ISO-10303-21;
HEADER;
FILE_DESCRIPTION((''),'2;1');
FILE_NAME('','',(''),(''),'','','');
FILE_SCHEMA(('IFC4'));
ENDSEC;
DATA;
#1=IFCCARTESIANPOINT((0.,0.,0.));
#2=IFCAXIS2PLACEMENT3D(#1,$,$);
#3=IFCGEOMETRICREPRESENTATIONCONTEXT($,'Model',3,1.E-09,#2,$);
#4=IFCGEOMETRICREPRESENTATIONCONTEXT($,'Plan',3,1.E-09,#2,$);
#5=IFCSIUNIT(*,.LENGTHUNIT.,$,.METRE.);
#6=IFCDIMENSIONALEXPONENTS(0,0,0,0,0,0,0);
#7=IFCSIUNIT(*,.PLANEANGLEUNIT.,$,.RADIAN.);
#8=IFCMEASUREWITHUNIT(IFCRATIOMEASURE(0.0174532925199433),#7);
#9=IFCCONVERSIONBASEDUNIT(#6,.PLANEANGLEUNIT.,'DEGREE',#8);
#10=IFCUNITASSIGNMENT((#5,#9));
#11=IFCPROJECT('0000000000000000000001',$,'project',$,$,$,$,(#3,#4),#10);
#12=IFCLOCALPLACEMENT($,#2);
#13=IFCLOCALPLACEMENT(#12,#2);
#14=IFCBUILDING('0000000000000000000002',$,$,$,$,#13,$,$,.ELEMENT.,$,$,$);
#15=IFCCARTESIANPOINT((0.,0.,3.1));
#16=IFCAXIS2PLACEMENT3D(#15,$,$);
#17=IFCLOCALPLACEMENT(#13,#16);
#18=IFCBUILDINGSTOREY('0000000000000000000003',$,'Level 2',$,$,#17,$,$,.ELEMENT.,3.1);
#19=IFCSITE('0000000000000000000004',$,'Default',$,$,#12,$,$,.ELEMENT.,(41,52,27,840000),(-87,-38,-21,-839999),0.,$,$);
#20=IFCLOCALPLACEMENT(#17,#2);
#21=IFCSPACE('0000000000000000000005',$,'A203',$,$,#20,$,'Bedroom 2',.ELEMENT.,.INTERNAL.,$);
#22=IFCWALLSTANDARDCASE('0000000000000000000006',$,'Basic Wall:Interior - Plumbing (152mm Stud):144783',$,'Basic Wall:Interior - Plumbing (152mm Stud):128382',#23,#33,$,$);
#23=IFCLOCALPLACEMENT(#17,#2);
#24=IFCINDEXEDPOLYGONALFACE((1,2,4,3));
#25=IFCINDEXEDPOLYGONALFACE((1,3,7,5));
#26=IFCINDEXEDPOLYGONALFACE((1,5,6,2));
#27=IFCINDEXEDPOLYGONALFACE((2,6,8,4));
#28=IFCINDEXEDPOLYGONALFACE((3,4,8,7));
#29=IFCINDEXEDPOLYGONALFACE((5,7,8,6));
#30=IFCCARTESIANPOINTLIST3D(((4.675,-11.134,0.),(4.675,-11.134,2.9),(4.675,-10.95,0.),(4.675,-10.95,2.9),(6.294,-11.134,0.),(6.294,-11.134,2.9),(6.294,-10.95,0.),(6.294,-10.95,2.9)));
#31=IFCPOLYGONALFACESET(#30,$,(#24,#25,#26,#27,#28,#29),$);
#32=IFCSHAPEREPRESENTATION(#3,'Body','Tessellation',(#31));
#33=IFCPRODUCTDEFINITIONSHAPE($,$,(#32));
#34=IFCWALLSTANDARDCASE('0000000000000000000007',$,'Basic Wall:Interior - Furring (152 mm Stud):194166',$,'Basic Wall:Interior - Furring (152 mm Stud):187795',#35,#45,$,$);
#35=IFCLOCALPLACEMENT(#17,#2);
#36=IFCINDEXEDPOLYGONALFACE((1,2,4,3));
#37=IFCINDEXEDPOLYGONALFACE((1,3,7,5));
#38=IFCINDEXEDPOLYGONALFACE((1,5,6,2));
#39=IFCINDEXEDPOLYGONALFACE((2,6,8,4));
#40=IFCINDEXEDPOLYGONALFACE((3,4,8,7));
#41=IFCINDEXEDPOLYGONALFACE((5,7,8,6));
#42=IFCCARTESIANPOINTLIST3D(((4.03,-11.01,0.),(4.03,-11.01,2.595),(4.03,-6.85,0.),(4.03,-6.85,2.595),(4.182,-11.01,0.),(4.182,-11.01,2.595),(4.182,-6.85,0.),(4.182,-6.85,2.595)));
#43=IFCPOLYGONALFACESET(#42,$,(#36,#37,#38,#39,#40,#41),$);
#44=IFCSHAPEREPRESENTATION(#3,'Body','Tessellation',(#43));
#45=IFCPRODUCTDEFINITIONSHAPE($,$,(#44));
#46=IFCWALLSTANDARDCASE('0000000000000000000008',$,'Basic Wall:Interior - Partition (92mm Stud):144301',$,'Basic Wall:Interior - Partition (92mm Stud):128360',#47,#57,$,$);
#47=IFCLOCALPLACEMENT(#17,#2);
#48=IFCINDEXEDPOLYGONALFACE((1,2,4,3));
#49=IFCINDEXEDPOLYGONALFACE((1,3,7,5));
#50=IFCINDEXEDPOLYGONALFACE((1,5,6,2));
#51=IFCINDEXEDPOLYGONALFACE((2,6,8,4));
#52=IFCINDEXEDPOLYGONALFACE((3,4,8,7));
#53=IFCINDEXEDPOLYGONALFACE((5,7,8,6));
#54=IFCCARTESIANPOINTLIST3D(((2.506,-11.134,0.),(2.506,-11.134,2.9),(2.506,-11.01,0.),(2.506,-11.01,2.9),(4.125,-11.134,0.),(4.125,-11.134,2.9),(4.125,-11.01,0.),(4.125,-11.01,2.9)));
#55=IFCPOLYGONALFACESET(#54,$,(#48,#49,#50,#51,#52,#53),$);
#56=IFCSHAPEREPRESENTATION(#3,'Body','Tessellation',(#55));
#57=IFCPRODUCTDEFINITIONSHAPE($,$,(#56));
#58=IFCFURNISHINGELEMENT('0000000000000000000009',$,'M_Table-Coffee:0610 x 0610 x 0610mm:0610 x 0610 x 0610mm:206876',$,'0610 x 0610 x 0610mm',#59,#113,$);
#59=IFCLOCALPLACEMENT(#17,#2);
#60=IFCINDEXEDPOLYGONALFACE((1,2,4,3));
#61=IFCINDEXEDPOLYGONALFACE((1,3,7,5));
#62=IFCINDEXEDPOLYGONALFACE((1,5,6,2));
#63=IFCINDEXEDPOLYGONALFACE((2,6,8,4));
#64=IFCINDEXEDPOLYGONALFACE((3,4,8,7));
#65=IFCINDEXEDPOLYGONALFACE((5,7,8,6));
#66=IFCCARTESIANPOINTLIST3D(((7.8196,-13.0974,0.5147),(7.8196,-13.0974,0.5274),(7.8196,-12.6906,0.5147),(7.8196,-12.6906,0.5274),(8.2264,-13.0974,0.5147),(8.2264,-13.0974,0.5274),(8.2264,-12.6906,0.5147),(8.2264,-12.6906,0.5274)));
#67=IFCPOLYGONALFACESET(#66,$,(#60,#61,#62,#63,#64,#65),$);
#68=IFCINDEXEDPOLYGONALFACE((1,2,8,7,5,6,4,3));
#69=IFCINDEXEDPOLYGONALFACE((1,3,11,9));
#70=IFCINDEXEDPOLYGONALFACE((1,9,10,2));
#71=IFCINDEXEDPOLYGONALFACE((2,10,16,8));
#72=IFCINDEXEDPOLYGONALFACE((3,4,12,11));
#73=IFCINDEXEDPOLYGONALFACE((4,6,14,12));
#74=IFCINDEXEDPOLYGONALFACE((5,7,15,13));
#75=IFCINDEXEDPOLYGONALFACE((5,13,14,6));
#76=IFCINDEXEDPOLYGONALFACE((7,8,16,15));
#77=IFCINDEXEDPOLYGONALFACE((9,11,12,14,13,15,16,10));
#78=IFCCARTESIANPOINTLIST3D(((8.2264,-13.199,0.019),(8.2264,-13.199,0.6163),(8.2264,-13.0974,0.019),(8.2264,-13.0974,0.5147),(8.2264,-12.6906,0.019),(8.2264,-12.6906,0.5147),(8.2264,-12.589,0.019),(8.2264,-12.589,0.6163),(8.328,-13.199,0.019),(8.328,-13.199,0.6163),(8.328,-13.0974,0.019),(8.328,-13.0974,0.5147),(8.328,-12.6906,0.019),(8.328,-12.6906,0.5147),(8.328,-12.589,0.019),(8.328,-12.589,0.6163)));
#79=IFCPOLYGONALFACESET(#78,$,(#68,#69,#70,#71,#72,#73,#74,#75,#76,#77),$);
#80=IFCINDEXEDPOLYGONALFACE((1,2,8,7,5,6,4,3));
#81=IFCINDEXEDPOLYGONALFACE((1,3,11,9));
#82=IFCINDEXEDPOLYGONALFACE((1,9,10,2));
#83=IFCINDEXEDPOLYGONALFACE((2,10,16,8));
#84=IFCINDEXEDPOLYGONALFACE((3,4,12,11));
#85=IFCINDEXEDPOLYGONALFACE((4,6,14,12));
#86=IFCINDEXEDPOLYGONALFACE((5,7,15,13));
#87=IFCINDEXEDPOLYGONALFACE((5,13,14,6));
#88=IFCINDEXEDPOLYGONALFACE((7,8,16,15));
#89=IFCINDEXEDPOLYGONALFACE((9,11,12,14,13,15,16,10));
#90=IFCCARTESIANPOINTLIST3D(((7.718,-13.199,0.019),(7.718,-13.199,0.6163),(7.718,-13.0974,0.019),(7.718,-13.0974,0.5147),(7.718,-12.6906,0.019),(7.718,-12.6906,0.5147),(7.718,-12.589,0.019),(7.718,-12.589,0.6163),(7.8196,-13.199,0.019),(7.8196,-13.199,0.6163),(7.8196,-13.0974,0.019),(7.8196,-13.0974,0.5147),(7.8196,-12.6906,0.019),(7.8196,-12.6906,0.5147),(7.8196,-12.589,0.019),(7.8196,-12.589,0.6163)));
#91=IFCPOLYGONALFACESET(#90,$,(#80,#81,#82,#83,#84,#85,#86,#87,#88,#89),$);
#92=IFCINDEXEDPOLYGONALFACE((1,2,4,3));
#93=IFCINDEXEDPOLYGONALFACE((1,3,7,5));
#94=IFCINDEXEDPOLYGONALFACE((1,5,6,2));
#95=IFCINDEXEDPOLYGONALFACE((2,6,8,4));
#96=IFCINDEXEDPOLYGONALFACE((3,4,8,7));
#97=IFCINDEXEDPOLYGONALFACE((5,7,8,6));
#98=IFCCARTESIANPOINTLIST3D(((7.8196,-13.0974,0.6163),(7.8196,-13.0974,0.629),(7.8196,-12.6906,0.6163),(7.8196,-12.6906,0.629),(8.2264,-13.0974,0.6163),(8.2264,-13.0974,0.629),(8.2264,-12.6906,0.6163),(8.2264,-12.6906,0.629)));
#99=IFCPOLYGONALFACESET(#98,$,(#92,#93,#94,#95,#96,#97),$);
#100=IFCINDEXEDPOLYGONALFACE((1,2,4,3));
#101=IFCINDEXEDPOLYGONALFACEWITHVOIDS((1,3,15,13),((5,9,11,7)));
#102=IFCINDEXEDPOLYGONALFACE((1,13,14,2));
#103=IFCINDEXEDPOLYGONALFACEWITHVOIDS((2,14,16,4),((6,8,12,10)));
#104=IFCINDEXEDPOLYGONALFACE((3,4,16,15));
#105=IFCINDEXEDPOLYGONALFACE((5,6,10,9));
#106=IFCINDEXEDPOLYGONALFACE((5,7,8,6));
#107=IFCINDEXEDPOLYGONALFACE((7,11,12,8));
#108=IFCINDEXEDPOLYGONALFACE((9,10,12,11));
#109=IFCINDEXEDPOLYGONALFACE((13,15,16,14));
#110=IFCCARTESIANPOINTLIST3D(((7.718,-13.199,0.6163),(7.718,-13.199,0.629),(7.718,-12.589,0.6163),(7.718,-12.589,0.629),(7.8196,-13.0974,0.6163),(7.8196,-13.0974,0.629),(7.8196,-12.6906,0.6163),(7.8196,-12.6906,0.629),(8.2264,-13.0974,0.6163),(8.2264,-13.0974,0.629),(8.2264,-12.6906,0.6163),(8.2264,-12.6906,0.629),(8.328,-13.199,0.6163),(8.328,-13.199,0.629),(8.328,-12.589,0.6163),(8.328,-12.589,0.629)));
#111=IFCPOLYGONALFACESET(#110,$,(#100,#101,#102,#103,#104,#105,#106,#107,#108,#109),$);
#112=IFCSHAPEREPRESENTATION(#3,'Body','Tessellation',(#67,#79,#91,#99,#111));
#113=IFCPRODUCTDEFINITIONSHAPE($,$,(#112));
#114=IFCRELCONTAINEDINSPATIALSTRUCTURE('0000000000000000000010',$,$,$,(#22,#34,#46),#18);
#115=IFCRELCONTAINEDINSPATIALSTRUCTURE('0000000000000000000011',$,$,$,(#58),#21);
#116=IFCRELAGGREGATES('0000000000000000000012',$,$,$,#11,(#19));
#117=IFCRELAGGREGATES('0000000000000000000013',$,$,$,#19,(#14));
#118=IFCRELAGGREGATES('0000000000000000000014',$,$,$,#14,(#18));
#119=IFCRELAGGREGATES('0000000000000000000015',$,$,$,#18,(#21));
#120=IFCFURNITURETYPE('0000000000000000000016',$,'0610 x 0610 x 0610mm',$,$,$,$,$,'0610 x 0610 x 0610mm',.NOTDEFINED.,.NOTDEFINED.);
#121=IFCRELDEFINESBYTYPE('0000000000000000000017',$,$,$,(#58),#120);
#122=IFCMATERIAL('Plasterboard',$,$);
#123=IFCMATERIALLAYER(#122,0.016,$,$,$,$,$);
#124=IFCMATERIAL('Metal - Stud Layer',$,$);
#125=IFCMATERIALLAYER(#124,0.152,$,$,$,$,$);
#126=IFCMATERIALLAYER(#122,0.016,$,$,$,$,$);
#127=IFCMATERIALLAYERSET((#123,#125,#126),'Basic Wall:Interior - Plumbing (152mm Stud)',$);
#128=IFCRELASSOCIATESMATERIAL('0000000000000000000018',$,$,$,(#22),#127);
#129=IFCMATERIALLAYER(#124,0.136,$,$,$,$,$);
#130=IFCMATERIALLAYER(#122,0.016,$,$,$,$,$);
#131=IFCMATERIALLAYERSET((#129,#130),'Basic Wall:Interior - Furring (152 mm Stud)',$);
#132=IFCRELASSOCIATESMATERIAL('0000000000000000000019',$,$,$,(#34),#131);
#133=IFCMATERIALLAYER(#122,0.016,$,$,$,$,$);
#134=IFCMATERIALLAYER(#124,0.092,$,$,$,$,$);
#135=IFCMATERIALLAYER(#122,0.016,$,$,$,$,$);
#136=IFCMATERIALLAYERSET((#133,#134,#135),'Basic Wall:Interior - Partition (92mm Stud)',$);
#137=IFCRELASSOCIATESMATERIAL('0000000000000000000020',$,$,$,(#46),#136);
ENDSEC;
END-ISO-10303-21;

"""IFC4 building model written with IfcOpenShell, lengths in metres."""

from ifc_helpers import new_model, entity, si_unit, converted_unit, frame, frame_2d, origin, origin_2d_with_axis, place, context, project, spatial, polyline, rectangle, outline, extrude, source, transform, mapped, material, layer, layer_set, layer_usage, type_object, type_shapes, element, save


model = new_model("IFC4")

# Units and contexts
model_context = context("Model", 3, precision=1e-09, world=origin())
plan_context = context("Plan", 3, precision=1e-09, world=origin())
ifc_project = project(units=[si_unit("LENGTHUNIT", "METRE"), converted_unit("PLANEANGLEUNIT", "DEGREE", entity("IfcRatioMeasure", 0.0174532925199433), si_unit("PLANEANGLEUNIT", "RADIAN"), dimensions=[0, 0, 0, 0, 0, 0, 0])], contexts=[model_context, plan_context])

# Site, building, storey
site_placement = place(None, origin())
site = spatial("IfcSite", under=ifc_project, at=site_placement, Name="Default", CompositionType="ELEMENT", RefLatitude=(41, 52, 27, 840000), RefLongitude=(-87, -38, -21, -839999), RefElevation=0.0)
building_placement = place(site_placement, origin())
building = spatial("IfcBuilding", under=site, at=building_placement, CompositionType="ELEMENT")
storey_placement = place(building_placement, frame((0.0, 0.0, 3.1)))
storey = spatial("IfcBuildingStorey", under=building, at=storey_placement, Name="Level 2", CompositionType="ELEMENT", Elevation=3.1)

# Shared definitions
ifc_material_1 = material(Name="Plasterboard")
ifc_layer_1 = layer(ifc_material_1, 0.016)
ifc_material_2 = material(Name="Metal - Stud Layer")
ifc_layer_2 = layer(ifc_material_2, 0.092)
ifc_layer_3 = layer(ifc_material_1, 0.016)
ifc_layer_set_1 = layer_set([ifc_layer_1, ifc_layer_2, ifc_layer_3], Name="Basic Wall:Interior - Partition (92mm Stud)")

# Walls
ifc_layer_4 = layer(ifc_material_1, 0.016)
ifc_layer_5 = layer(ifc_material_2, 0.152)
ifc_layer_6 = layer(ifc_material_1, 0.016)
ifc_layer_set_2 = layer_set([ifc_layer_4, ifc_layer_5, ifc_layer_6], Name="Basic Wall:Interior - Plumbing (152mm Stud)")
ifc_layer_usage_1 = layer_usage(ifc_layer_set_2, "AXIS2", "NEGATIVE", 0.092)
wall_1_placement = place(storey_placement, frame((6.294, -11.042, 0.0), z_axis=(0.0, 0.0, 1.0), x_axis=(-1.0, 0.0, 0.0)))
element("IfcWallStandardCase", 1, at=wall_1_placement, inside=storey, material=ifc_layer_usage_1, Name="Basic Wall:Interior - Plumbing (152mm Stud):144783", ObjectType="Basic Wall:Interior - Plumbing (152mm Stud):128382", context=model_context, shape_type="SweptSolid", body=[
    extrude(rectangle(XDim=1.619, YDim=0.184, at=frame_2d((0.8095, 0.0), x_axis=(-1.0, 0.0))), origin(), (0.0, 0.0, 1.0), 2.9),
])
ifc_layer_7 = layer(ifc_material_2, 0.136)
ifc_layer_8 = layer(ifc_material_1, 0.016)
ifc_layer_set_3 = layer_set([ifc_layer_7, ifc_layer_8], Name="Basic Wall:Interior - Furring (152 mm Stud)")
ifc_layer_usage_2 = layer_usage(ifc_layer_set_3, "AXIS2", "POSITIVE", -0.076)
wall_2_placement = place(storey_placement, frame((4.106, -11.01, 0.0), z_axis=(0.0, 0.0, 1.0), x_axis=(0.0, 1.0, 0.0)))
element("IfcWallStandardCase", 2, at=wall_2_placement, inside=storey, material=ifc_layer_usage_2, Name="Basic Wall:Interior - Furring (152 mm Stud):194166", ObjectType="Basic Wall:Interior - Furring (152 mm Stud):187795", context=model_context, shape_type="SweptSolid", body=[
    extrude(rectangle(XDim=4.16, YDim=0.152, at=frame_2d((2.08, 0.0), x_axis=(-1.0, 0.0))), origin(), (0.0, 0.0, 1.0), 2.595),
])
ifc_layer_usage_3 = layer_usage(ifc_layer_set_1, "AXIS2", "NEGATIVE", 0.062)
wall_3_placement = place(storey_placement, frame((4.125, -11.072, 0.0), z_axis=(0.0, 0.0, 1.0), x_axis=(-1.0, 0.0, 0.0)))
element("IfcWallStandardCase", 3, at=wall_3_placement, inside=storey, material=ifc_layer_usage_3, Name="Basic Wall:Interior - Partition (92mm Stud):144301", ObjectType="Basic Wall:Interior - Partition (92mm Stud):128360", context=model_context, shape_type="SweptSolid", body=[
    extrude(rectangle(XDim=1.619, YDim=0.124, at=frame_2d((0.8095, 0.0), x_axis=(-1.0, 0.0))), origin(), (0.0, 0.0, 1.0), 2.9),
])

# Shared definitions
space_placement = place(storey_placement, origin())
space = spatial("IfcSpace", under=storey, at=space_placement, Name="A203", LongName="Bedroom 2", CompositionType="ELEMENT", PredefinedType="INTERNAL")

# Furnishing element
furniture_type = type_object("IfcFurnitureType", Name="0610 x 0610 x 0610mm", ElementType="0610 x 0610 x 0610mm", AssemblyPlace="NOTDEFINED")
shared_shape_1 = source(origin(), model_context, "Body", "SweptSolid", [
    extrude(rectangle(XDim=0.4068, YDim=0.4068, at=origin_2d_with_axis()), frame((0.0183, 0.0952, 0.4957), z_axis=(0.0, 0.0, 1.0), x_axis=(-1.0, 0.0, 0.0)), (0.0, 0.0, 1.0), 0.0127),
    extrude(outline(polyline([(-0.2732, -0.305), (0.324, -0.305), (0.324, 0.305), (-0.2732, 0.305), (-0.2732, 0.2034), (0.2225, 0.2034), (0.2225, -0.2034), (-0.2732, -0.2034), (-0.2732, -0.305)])), frame((0.2217, 0.0952, 0.2732), z_axis=(1.0, 0.0, 0.0), x_axis=(0.0, 0.0, 1.0)), (0.0, 0.0, 1.0), 0.1016),
    extrude(outline(polyline([(-0.305, -0.3241), (0.305, -0.3241), (0.305, 0.2733), (0.2034, 0.2733), (0.2034, -0.2224), (-0.2034, -0.2224), (-0.2034, 0.2733), (-0.305, 0.2733), (-0.305, -0.3241)])), frame((-0.2867, 0.0952, 0.2733), z_axis=(1.0, 0.0, 0.0), x_axis=(0.0, -1.0, 0.0)), (0.0, 0.0, 1.0), 0.1016),
    extrude(rectangle(XDim=0.4068, YDim=0.4068, at=origin_2d_with_axis()), frame((0.0183, 0.0952, 0.5973), z_axis=(0.0, 0.0, 1.0), x_axis=(-1.0, 0.0, 0.0)), (0.0, 0.0, 1.0), 0.0127),
    extrude(outline(polyline([(-0.305, -0.305), (0.305, -0.305), (0.305, 0.305), (-0.305, 0.305), (-0.305, -0.305)]), holes=[polyline([(-0.2034, -0.2034), (-0.2034, 0.2034), (0.2034, 0.2034), (0.2034, -0.2034), (-0.2034, -0.2034)])]), frame((0.0183, 0.0952, 0.5973), z_axis=(0.0, 0.0, 1.0), x_axis=(-1.0, 0.0, 0.0)), (0.0, 0.0, 1.0), 0.0127),
])
type_shapes(furniture_type, [shared_shape_1])
furnishing_placement = place(space_placement, frame((8.0047, -12.9892, 0.019)))
element("IfcFurnishingElement", 4, at=furnishing_placement, inside=space, type_object=furniture_type, Name="M_Table-Coffee:0610 x 0610 x 0610mm:0610 x 0610 x 0610mm:206876", ObjectType="0610 x 0610 x 0610mm", context=model_context, shape_type="MappedRepresentation", body=[
    mapped(shared_shape_1, transform((0.0, 0.0, 0.0), scale=1.0)),
])

save(model, "model.ifc")
